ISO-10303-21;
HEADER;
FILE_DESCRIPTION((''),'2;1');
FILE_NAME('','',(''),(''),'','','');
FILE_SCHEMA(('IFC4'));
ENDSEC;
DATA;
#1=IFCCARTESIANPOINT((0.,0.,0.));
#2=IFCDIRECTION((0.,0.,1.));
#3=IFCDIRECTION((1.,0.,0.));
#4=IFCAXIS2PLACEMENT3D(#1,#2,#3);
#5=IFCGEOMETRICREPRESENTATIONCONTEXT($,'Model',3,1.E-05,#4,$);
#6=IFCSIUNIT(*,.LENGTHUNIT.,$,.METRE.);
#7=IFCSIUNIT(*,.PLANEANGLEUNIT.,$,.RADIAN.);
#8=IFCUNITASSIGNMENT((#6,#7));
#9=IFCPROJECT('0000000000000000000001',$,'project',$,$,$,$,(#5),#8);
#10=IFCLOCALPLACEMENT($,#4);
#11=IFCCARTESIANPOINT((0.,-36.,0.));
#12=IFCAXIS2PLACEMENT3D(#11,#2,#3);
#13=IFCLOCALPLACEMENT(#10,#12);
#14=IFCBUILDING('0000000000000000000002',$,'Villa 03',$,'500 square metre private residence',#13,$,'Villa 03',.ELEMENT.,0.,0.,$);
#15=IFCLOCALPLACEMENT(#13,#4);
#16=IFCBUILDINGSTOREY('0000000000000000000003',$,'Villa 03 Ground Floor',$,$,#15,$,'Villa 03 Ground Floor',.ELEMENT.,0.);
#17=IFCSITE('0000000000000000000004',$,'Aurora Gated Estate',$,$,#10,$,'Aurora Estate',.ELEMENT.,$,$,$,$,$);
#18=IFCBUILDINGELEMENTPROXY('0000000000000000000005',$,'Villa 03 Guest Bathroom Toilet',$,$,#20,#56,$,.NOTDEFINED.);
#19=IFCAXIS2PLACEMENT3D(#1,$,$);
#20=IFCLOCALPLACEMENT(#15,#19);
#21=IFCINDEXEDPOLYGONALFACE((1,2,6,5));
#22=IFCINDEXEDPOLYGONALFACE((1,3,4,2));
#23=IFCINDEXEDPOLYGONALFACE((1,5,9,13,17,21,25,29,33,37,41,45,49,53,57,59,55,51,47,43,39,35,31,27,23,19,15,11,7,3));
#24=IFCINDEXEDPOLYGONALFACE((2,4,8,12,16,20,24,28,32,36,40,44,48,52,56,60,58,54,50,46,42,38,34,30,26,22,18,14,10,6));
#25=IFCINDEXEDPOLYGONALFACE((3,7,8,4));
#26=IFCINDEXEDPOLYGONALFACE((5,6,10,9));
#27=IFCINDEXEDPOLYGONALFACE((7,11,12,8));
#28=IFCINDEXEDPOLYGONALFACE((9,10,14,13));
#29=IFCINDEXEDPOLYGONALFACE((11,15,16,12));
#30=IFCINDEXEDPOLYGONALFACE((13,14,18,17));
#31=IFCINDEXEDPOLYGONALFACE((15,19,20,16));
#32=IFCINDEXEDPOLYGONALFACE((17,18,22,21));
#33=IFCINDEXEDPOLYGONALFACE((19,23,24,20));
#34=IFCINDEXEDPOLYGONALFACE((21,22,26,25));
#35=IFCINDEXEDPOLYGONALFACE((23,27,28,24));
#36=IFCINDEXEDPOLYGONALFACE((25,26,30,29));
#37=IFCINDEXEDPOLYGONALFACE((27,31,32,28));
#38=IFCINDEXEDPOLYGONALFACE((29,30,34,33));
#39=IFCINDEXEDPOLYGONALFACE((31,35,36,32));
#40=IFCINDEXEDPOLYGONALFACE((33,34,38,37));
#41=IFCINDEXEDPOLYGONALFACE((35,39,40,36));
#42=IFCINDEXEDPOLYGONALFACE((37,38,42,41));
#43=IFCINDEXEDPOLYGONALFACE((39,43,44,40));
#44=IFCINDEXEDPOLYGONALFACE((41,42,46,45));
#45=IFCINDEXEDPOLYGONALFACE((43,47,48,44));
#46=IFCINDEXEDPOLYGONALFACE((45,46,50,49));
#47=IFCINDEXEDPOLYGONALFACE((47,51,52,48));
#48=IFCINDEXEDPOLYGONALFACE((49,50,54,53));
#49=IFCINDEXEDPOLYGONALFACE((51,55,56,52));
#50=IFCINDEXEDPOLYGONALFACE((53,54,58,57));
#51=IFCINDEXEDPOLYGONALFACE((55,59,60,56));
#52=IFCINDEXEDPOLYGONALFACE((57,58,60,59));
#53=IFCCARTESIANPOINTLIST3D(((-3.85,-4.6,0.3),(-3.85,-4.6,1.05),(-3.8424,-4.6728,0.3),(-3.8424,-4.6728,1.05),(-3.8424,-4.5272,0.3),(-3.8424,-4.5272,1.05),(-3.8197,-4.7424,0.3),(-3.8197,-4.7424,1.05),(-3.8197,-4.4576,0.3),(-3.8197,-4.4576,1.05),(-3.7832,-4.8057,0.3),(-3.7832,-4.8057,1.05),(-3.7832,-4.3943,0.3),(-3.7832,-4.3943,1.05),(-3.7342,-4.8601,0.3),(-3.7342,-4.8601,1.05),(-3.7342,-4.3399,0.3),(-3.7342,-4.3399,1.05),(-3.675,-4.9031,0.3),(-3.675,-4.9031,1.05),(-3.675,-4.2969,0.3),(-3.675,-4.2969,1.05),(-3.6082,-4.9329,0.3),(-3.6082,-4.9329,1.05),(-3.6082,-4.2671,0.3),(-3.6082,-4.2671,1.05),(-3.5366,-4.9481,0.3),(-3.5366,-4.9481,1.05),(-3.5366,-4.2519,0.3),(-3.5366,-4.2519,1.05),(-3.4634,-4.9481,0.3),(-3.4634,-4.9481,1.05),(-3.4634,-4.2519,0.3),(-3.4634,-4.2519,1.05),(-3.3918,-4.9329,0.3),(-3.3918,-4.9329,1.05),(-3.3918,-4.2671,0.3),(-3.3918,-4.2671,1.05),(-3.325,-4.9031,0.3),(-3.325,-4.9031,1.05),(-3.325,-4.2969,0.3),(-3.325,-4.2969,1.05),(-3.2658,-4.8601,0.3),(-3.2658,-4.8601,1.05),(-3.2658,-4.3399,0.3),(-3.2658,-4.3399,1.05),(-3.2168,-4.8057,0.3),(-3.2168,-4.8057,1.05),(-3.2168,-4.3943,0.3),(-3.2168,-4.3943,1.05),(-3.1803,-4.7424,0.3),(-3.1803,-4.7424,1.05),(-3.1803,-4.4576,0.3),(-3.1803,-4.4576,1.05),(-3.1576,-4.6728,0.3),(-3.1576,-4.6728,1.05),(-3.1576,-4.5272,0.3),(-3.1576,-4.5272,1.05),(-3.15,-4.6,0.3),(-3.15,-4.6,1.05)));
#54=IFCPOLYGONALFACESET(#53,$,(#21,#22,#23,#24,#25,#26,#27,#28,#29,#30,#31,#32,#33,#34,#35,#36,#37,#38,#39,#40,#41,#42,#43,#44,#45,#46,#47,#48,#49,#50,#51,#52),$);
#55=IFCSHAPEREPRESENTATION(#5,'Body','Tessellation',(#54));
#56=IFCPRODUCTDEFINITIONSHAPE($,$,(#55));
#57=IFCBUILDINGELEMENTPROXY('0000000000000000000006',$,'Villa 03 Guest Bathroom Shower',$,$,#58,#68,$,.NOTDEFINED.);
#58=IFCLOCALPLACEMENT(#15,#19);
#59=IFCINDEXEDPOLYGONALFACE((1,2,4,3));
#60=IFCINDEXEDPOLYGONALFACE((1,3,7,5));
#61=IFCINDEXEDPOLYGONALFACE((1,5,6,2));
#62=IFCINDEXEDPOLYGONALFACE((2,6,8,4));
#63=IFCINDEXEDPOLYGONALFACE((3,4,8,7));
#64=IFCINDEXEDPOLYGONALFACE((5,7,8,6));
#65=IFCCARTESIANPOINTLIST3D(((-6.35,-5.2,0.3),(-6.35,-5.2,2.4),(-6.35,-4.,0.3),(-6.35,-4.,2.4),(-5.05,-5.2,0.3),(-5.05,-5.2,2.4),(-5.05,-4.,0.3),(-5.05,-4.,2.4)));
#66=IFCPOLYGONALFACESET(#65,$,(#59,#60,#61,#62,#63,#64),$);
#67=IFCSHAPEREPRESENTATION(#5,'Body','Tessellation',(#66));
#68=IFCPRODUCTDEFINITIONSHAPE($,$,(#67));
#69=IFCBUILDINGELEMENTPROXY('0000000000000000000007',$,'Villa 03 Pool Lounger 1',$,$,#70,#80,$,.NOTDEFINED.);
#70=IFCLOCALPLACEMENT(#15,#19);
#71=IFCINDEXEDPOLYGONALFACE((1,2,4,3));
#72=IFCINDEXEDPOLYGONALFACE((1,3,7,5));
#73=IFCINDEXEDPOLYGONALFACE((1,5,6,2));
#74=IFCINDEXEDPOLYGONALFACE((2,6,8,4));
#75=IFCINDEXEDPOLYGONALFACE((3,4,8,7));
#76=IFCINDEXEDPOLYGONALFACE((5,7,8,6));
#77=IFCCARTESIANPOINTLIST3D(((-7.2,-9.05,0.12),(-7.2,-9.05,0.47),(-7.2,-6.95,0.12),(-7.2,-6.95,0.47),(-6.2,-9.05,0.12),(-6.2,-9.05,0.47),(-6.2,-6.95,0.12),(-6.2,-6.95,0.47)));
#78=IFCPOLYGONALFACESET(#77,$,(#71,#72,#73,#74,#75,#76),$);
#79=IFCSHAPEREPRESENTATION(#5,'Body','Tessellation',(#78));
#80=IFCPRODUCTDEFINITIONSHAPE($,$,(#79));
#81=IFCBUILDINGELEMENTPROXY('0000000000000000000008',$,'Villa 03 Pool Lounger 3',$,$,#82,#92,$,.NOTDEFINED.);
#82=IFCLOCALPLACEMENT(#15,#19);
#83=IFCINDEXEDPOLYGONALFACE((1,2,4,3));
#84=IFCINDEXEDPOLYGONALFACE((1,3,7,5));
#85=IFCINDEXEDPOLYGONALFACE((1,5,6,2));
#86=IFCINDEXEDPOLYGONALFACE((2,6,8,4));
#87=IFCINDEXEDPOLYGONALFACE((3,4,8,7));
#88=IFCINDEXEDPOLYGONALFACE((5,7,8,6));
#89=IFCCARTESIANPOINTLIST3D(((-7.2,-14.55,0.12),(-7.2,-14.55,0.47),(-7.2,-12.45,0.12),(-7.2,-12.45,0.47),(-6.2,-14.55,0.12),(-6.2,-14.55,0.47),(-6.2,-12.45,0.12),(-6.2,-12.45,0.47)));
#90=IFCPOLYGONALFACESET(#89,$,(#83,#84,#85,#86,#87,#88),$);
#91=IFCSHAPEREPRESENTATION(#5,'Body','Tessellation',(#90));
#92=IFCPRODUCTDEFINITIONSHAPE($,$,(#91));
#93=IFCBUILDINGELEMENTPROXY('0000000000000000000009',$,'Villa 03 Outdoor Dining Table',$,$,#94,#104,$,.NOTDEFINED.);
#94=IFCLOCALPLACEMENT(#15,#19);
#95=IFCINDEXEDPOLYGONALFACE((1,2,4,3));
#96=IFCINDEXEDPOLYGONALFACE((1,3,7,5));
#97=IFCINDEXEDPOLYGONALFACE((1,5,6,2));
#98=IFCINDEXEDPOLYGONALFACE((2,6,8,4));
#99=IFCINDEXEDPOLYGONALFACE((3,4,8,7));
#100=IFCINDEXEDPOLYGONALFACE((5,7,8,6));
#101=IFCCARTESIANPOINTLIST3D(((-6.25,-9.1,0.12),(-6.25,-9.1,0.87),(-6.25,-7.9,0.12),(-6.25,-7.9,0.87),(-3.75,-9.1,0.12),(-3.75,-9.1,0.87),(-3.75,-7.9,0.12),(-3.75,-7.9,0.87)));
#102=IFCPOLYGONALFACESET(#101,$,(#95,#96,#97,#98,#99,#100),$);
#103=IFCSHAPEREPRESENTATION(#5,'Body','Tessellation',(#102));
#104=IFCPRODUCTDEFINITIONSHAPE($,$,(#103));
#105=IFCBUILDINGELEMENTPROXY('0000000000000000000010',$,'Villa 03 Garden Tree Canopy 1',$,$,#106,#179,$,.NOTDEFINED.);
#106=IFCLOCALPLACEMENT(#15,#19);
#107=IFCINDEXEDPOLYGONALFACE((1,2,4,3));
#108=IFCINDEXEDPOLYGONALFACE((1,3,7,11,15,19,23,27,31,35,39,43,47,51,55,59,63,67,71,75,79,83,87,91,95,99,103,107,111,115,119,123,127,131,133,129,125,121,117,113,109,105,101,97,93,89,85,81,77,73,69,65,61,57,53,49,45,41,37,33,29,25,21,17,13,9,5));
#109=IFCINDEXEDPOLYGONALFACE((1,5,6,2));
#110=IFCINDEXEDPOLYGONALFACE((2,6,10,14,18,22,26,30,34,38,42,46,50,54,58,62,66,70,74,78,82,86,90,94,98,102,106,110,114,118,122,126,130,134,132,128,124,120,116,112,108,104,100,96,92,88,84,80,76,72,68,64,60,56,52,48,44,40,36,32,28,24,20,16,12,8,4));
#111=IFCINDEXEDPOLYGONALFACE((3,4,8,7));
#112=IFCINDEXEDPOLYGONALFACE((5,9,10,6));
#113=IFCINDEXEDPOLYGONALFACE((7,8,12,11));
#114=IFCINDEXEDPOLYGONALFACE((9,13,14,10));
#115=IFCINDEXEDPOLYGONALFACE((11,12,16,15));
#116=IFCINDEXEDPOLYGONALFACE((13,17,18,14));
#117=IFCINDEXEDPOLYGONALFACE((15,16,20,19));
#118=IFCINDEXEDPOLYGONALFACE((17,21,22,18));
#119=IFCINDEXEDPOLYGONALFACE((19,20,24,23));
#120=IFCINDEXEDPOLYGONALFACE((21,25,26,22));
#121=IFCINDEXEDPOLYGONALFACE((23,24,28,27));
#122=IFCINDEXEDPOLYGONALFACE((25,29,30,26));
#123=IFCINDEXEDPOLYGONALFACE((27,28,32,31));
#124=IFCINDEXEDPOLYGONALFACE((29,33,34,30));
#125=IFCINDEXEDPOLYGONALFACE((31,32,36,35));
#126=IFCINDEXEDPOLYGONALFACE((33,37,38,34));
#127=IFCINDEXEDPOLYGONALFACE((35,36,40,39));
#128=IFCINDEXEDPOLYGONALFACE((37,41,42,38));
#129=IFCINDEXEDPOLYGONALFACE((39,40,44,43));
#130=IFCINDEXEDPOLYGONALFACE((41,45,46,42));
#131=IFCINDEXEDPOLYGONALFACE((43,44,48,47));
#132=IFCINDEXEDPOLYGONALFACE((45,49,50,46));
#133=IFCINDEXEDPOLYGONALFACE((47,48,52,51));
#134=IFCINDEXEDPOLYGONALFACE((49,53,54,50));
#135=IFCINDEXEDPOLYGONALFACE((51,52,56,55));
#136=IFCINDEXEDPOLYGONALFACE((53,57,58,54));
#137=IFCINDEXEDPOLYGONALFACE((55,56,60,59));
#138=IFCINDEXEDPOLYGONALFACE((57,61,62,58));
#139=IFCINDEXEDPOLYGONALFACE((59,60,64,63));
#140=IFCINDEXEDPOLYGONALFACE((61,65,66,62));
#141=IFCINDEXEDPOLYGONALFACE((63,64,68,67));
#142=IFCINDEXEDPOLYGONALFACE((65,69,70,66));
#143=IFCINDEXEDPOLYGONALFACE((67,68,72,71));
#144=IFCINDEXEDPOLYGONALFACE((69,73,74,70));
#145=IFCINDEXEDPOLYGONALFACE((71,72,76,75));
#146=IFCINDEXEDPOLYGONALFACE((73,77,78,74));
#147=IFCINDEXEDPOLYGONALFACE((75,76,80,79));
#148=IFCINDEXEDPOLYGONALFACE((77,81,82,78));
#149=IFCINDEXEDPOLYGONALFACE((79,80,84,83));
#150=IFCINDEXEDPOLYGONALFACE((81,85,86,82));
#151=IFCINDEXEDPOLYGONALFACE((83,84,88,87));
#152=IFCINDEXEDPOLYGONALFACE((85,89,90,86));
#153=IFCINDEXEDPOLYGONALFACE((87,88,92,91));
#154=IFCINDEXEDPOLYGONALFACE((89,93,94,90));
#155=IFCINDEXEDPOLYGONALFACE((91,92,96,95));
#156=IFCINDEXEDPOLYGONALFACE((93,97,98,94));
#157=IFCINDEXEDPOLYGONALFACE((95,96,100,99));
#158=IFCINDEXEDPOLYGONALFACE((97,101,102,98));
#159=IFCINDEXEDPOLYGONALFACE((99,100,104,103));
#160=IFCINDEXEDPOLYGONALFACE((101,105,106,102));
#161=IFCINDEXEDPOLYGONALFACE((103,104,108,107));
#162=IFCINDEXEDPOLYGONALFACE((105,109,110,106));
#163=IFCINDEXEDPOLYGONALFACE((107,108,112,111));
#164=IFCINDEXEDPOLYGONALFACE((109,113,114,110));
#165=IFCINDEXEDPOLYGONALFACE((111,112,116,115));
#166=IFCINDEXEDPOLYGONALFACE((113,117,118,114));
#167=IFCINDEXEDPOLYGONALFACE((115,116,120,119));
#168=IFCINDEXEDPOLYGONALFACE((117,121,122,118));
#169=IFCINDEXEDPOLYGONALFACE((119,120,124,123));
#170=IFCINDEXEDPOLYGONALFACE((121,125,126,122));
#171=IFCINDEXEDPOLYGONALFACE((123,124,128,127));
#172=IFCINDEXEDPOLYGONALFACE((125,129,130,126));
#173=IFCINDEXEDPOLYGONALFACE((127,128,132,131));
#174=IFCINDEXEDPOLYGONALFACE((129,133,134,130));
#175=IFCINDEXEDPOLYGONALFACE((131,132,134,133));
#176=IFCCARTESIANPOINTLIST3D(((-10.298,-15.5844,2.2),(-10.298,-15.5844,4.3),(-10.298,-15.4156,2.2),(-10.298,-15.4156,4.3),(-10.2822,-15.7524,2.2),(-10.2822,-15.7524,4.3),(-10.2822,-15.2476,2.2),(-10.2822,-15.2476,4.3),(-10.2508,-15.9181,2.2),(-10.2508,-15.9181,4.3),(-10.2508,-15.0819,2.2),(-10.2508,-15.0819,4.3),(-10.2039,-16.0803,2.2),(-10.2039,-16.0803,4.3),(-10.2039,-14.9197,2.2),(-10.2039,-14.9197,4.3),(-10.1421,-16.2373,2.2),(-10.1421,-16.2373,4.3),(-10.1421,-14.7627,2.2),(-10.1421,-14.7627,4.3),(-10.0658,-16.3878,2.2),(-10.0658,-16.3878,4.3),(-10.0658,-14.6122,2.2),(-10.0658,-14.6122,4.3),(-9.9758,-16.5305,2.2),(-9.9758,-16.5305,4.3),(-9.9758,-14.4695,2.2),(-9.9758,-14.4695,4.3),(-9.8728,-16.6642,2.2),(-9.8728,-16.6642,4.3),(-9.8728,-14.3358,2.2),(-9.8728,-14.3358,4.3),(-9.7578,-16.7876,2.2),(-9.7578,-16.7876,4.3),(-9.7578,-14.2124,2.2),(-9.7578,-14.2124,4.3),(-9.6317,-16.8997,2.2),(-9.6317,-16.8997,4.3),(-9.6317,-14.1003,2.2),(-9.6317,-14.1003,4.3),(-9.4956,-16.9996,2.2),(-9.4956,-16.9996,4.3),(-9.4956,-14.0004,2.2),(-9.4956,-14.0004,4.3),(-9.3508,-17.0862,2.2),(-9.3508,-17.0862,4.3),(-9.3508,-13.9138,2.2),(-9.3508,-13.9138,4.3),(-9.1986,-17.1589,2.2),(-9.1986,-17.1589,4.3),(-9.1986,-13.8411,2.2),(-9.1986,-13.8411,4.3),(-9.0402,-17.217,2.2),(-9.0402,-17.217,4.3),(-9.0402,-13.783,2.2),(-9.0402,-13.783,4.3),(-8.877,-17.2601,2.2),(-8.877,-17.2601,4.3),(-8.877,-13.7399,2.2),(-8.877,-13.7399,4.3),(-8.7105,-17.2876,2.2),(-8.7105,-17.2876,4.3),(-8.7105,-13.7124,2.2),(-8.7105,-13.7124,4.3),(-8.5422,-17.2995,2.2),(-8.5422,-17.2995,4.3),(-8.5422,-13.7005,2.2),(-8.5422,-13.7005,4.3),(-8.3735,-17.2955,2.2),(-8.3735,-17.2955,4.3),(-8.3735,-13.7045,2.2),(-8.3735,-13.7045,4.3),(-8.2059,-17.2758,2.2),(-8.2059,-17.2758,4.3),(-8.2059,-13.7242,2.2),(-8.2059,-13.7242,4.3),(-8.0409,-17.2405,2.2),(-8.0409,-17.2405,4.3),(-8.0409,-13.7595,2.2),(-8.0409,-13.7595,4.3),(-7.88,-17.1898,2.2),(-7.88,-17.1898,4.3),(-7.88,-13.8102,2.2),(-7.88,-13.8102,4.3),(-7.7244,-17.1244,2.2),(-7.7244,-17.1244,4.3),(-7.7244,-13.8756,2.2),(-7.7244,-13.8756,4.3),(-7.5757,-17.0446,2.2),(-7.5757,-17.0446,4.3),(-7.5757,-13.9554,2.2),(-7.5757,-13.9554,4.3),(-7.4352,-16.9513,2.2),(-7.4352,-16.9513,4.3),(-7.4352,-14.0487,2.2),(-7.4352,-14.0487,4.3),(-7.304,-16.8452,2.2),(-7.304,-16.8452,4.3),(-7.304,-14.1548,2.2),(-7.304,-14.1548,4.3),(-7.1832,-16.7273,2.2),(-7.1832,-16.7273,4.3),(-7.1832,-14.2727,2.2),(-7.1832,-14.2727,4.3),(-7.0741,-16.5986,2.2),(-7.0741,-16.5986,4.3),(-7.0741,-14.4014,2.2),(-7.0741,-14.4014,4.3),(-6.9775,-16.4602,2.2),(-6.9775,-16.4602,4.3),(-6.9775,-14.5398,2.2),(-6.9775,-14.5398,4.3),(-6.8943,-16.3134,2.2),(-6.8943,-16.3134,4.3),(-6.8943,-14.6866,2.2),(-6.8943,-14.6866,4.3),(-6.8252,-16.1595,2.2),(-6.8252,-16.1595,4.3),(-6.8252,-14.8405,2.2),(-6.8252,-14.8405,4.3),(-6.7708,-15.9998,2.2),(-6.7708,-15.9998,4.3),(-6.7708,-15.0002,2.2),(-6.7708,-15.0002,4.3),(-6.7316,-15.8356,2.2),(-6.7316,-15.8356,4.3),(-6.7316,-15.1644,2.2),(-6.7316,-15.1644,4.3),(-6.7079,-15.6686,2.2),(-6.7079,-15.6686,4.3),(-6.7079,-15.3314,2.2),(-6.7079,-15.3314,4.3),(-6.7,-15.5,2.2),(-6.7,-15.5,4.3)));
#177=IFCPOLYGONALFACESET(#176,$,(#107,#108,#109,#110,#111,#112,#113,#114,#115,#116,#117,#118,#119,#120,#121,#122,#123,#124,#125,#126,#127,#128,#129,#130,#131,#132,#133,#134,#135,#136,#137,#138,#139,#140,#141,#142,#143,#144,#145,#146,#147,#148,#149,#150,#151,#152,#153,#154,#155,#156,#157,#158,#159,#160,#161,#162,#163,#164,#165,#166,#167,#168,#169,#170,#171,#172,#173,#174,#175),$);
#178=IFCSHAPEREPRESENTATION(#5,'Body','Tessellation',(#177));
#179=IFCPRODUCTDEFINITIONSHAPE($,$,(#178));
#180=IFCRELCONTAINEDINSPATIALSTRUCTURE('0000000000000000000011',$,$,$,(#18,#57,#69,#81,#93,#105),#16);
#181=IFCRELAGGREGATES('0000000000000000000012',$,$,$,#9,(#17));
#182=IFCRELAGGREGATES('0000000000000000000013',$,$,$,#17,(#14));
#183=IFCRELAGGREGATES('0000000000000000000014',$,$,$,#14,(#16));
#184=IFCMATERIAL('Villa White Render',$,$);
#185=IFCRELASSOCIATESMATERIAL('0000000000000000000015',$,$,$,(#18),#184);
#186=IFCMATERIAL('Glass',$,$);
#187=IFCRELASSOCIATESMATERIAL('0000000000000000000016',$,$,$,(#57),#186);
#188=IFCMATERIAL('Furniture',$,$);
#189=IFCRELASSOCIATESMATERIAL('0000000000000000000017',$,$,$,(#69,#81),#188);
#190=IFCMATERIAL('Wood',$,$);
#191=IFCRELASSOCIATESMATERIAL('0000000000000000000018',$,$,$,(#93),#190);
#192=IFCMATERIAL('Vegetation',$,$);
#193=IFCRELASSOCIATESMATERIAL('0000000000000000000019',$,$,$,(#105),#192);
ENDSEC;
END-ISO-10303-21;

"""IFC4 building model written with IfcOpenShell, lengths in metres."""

from ifc_helpers import new_model, si_unit, frame, origin_with_axes, origin_2d_with_axis, place, context, project, spatial, rectangle, circle, extrude, material, element, save


model = new_model("IFC4")

# Units and contexts
model_context = context("Model", 3, precision=1e-05, world=origin_with_axes())
ifc_project = project(units=[si_unit("LENGTHUNIT", "METRE"), si_unit("PLANEANGLEUNIT", "RADIAN")], contexts=[model_context])

# Site, building, storey
site_placement = place(None, origin_with_axes())
site = spatial("IfcSite", under=ifc_project, at=site_placement, Name="Aurora Gated Estate", LongName="Aurora Estate", CompositionType="ELEMENT")
building_placement = place(site_placement, frame((0.0, -36.0, 0.0), z_axis=(0.0, 0.0, 1.0), x_axis=(1.0, 0.0, 0.0)))
building = spatial("IfcBuilding", under=site, at=building_placement, Name="Villa 03", ObjectType="500 square metre private residence", LongName="Villa 03", CompositionType="ELEMENT", ElevationOfRefHeight=0.0, ElevationOfTerrain=0.0)
storey_placement = place(building_placement, origin_with_axes())
storey = spatial("IfcBuildingStorey", under=building, at=storey_placement, Name="Villa 03 Ground Floor", LongName="Villa 03 Ground Floor", CompositionType="ELEMENT", Elevation=0.0)

# Shared definitions
ifc_material_1 = material(Name="Wood")

# Building element proxies
ifc_material_2 = material(Name="Furniture")
ifc_material_3 = material(Name="Villa White Render")
proxy_1_placement = place(storey_placement, frame((-3.5, -4.6, 0.3), z_axis=(0.0, 0.0, 1.0), x_axis=(1.0, 0.0, 0.0)))
element("IfcBuildingElementProxy", 1, at=proxy_1_placement, inside=storey, material=ifc_material_3, Name="Villa 03 Guest Bathroom Toilet", PredefinedType="NOTDEFINED", context=model_context, shape_type="SweptSolid", body=[
    extrude(circle(Radius=0.35, at=origin_2d_with_axis()), origin_with_axes(), (0.0, 0.0, 1.0), 0.75),
])
ifc_material_4 = material(Name="Glass")
proxy_2_placement = place(storey_placement, frame((-5.7, -4.6, 0.3), z_axis=(0.0, 0.0, 1.0), x_axis=(1.0, 0.0, 0.0)))
element("IfcBuildingElementProxy", 2, at=proxy_2_placement, inside=storey, material=ifc_material_4, Name="Villa 03 Guest Bathroom Shower", PredefinedType="NOTDEFINED", context=model_context, shape_type="SweptSolid", body=[
    extrude(rectangle(XDim=1.3, YDim=1.2, at=origin_2d_with_axis()), origin_with_axes(), (0.0, 0.0, 1.0), 2.1),
])
for number, where, z_axis, x_axis, name in (
    (3, (-6.7, -8.0, 0.12), (0.0, 0.0, 1.0), (1.0, 0.0, 0.0), "Villa 03 Pool Lounger 1"),
    (4, (-6.7, -13.5, 0.12), (0.0, 0.0, 1.0), (1.0, 0.0, 0.0), "Villa 03 Pool Lounger 3"),
):
    element("IfcBuildingElementProxy", number, at=place(storey_placement, frame(where, z_axis=z_axis, x_axis=x_axis)), inside=storey, material=ifc_material_2, Name=name, PredefinedType="NOTDEFINED", context=model_context, shape_type="SweptSolid", body=[
        extrude(rectangle(XDim=1.0, YDim=2.1, at=origin_2d_with_axis()), origin_with_axes(), (0.0, 0.0, 1.0), 0.35),
    ])
proxy_3_placement = place(storey_placement, frame((-5.0, -8.5, 0.12), z_axis=(0.0, 0.0, 1.0), x_axis=(1.0, 0.0, 0.0)))
element("IfcBuildingElementProxy", 5, at=proxy_3_placement, inside=storey, material=ifc_material_1, Name="Villa 03 Outdoor Dining Table", PredefinedType="NOTDEFINED", context=model_context, shape_type="SweptSolid", body=[
    extrude(rectangle(XDim=2.5, YDim=1.2, at=origin_2d_with_axis()), origin_with_axes(), (0.0, 0.0, 1.0), 0.75),
])
ifc_material_5 = material(Name="Vegetation")
proxy_4_placement = place(storey_placement, frame((-8.5, -15.5, 2.2), z_axis=(0.0, 0.0, 1.0), x_axis=(1.0, 0.0, 0.0)))
element("IfcBuildingElementProxy", 6, at=proxy_4_placement, inside=storey, material=ifc_material_5, Name="Villa 03 Garden Tree Canopy 1", PredefinedType="NOTDEFINED", context=model_context, shape_type="SweptSolid", body=[
    extrude(circle(Radius=1.8, at=origin_2d_with_axis()), origin_with_axes(), (0.0, 0.0, 1.0), 2.1),
])

save(model, "model.ifc")
